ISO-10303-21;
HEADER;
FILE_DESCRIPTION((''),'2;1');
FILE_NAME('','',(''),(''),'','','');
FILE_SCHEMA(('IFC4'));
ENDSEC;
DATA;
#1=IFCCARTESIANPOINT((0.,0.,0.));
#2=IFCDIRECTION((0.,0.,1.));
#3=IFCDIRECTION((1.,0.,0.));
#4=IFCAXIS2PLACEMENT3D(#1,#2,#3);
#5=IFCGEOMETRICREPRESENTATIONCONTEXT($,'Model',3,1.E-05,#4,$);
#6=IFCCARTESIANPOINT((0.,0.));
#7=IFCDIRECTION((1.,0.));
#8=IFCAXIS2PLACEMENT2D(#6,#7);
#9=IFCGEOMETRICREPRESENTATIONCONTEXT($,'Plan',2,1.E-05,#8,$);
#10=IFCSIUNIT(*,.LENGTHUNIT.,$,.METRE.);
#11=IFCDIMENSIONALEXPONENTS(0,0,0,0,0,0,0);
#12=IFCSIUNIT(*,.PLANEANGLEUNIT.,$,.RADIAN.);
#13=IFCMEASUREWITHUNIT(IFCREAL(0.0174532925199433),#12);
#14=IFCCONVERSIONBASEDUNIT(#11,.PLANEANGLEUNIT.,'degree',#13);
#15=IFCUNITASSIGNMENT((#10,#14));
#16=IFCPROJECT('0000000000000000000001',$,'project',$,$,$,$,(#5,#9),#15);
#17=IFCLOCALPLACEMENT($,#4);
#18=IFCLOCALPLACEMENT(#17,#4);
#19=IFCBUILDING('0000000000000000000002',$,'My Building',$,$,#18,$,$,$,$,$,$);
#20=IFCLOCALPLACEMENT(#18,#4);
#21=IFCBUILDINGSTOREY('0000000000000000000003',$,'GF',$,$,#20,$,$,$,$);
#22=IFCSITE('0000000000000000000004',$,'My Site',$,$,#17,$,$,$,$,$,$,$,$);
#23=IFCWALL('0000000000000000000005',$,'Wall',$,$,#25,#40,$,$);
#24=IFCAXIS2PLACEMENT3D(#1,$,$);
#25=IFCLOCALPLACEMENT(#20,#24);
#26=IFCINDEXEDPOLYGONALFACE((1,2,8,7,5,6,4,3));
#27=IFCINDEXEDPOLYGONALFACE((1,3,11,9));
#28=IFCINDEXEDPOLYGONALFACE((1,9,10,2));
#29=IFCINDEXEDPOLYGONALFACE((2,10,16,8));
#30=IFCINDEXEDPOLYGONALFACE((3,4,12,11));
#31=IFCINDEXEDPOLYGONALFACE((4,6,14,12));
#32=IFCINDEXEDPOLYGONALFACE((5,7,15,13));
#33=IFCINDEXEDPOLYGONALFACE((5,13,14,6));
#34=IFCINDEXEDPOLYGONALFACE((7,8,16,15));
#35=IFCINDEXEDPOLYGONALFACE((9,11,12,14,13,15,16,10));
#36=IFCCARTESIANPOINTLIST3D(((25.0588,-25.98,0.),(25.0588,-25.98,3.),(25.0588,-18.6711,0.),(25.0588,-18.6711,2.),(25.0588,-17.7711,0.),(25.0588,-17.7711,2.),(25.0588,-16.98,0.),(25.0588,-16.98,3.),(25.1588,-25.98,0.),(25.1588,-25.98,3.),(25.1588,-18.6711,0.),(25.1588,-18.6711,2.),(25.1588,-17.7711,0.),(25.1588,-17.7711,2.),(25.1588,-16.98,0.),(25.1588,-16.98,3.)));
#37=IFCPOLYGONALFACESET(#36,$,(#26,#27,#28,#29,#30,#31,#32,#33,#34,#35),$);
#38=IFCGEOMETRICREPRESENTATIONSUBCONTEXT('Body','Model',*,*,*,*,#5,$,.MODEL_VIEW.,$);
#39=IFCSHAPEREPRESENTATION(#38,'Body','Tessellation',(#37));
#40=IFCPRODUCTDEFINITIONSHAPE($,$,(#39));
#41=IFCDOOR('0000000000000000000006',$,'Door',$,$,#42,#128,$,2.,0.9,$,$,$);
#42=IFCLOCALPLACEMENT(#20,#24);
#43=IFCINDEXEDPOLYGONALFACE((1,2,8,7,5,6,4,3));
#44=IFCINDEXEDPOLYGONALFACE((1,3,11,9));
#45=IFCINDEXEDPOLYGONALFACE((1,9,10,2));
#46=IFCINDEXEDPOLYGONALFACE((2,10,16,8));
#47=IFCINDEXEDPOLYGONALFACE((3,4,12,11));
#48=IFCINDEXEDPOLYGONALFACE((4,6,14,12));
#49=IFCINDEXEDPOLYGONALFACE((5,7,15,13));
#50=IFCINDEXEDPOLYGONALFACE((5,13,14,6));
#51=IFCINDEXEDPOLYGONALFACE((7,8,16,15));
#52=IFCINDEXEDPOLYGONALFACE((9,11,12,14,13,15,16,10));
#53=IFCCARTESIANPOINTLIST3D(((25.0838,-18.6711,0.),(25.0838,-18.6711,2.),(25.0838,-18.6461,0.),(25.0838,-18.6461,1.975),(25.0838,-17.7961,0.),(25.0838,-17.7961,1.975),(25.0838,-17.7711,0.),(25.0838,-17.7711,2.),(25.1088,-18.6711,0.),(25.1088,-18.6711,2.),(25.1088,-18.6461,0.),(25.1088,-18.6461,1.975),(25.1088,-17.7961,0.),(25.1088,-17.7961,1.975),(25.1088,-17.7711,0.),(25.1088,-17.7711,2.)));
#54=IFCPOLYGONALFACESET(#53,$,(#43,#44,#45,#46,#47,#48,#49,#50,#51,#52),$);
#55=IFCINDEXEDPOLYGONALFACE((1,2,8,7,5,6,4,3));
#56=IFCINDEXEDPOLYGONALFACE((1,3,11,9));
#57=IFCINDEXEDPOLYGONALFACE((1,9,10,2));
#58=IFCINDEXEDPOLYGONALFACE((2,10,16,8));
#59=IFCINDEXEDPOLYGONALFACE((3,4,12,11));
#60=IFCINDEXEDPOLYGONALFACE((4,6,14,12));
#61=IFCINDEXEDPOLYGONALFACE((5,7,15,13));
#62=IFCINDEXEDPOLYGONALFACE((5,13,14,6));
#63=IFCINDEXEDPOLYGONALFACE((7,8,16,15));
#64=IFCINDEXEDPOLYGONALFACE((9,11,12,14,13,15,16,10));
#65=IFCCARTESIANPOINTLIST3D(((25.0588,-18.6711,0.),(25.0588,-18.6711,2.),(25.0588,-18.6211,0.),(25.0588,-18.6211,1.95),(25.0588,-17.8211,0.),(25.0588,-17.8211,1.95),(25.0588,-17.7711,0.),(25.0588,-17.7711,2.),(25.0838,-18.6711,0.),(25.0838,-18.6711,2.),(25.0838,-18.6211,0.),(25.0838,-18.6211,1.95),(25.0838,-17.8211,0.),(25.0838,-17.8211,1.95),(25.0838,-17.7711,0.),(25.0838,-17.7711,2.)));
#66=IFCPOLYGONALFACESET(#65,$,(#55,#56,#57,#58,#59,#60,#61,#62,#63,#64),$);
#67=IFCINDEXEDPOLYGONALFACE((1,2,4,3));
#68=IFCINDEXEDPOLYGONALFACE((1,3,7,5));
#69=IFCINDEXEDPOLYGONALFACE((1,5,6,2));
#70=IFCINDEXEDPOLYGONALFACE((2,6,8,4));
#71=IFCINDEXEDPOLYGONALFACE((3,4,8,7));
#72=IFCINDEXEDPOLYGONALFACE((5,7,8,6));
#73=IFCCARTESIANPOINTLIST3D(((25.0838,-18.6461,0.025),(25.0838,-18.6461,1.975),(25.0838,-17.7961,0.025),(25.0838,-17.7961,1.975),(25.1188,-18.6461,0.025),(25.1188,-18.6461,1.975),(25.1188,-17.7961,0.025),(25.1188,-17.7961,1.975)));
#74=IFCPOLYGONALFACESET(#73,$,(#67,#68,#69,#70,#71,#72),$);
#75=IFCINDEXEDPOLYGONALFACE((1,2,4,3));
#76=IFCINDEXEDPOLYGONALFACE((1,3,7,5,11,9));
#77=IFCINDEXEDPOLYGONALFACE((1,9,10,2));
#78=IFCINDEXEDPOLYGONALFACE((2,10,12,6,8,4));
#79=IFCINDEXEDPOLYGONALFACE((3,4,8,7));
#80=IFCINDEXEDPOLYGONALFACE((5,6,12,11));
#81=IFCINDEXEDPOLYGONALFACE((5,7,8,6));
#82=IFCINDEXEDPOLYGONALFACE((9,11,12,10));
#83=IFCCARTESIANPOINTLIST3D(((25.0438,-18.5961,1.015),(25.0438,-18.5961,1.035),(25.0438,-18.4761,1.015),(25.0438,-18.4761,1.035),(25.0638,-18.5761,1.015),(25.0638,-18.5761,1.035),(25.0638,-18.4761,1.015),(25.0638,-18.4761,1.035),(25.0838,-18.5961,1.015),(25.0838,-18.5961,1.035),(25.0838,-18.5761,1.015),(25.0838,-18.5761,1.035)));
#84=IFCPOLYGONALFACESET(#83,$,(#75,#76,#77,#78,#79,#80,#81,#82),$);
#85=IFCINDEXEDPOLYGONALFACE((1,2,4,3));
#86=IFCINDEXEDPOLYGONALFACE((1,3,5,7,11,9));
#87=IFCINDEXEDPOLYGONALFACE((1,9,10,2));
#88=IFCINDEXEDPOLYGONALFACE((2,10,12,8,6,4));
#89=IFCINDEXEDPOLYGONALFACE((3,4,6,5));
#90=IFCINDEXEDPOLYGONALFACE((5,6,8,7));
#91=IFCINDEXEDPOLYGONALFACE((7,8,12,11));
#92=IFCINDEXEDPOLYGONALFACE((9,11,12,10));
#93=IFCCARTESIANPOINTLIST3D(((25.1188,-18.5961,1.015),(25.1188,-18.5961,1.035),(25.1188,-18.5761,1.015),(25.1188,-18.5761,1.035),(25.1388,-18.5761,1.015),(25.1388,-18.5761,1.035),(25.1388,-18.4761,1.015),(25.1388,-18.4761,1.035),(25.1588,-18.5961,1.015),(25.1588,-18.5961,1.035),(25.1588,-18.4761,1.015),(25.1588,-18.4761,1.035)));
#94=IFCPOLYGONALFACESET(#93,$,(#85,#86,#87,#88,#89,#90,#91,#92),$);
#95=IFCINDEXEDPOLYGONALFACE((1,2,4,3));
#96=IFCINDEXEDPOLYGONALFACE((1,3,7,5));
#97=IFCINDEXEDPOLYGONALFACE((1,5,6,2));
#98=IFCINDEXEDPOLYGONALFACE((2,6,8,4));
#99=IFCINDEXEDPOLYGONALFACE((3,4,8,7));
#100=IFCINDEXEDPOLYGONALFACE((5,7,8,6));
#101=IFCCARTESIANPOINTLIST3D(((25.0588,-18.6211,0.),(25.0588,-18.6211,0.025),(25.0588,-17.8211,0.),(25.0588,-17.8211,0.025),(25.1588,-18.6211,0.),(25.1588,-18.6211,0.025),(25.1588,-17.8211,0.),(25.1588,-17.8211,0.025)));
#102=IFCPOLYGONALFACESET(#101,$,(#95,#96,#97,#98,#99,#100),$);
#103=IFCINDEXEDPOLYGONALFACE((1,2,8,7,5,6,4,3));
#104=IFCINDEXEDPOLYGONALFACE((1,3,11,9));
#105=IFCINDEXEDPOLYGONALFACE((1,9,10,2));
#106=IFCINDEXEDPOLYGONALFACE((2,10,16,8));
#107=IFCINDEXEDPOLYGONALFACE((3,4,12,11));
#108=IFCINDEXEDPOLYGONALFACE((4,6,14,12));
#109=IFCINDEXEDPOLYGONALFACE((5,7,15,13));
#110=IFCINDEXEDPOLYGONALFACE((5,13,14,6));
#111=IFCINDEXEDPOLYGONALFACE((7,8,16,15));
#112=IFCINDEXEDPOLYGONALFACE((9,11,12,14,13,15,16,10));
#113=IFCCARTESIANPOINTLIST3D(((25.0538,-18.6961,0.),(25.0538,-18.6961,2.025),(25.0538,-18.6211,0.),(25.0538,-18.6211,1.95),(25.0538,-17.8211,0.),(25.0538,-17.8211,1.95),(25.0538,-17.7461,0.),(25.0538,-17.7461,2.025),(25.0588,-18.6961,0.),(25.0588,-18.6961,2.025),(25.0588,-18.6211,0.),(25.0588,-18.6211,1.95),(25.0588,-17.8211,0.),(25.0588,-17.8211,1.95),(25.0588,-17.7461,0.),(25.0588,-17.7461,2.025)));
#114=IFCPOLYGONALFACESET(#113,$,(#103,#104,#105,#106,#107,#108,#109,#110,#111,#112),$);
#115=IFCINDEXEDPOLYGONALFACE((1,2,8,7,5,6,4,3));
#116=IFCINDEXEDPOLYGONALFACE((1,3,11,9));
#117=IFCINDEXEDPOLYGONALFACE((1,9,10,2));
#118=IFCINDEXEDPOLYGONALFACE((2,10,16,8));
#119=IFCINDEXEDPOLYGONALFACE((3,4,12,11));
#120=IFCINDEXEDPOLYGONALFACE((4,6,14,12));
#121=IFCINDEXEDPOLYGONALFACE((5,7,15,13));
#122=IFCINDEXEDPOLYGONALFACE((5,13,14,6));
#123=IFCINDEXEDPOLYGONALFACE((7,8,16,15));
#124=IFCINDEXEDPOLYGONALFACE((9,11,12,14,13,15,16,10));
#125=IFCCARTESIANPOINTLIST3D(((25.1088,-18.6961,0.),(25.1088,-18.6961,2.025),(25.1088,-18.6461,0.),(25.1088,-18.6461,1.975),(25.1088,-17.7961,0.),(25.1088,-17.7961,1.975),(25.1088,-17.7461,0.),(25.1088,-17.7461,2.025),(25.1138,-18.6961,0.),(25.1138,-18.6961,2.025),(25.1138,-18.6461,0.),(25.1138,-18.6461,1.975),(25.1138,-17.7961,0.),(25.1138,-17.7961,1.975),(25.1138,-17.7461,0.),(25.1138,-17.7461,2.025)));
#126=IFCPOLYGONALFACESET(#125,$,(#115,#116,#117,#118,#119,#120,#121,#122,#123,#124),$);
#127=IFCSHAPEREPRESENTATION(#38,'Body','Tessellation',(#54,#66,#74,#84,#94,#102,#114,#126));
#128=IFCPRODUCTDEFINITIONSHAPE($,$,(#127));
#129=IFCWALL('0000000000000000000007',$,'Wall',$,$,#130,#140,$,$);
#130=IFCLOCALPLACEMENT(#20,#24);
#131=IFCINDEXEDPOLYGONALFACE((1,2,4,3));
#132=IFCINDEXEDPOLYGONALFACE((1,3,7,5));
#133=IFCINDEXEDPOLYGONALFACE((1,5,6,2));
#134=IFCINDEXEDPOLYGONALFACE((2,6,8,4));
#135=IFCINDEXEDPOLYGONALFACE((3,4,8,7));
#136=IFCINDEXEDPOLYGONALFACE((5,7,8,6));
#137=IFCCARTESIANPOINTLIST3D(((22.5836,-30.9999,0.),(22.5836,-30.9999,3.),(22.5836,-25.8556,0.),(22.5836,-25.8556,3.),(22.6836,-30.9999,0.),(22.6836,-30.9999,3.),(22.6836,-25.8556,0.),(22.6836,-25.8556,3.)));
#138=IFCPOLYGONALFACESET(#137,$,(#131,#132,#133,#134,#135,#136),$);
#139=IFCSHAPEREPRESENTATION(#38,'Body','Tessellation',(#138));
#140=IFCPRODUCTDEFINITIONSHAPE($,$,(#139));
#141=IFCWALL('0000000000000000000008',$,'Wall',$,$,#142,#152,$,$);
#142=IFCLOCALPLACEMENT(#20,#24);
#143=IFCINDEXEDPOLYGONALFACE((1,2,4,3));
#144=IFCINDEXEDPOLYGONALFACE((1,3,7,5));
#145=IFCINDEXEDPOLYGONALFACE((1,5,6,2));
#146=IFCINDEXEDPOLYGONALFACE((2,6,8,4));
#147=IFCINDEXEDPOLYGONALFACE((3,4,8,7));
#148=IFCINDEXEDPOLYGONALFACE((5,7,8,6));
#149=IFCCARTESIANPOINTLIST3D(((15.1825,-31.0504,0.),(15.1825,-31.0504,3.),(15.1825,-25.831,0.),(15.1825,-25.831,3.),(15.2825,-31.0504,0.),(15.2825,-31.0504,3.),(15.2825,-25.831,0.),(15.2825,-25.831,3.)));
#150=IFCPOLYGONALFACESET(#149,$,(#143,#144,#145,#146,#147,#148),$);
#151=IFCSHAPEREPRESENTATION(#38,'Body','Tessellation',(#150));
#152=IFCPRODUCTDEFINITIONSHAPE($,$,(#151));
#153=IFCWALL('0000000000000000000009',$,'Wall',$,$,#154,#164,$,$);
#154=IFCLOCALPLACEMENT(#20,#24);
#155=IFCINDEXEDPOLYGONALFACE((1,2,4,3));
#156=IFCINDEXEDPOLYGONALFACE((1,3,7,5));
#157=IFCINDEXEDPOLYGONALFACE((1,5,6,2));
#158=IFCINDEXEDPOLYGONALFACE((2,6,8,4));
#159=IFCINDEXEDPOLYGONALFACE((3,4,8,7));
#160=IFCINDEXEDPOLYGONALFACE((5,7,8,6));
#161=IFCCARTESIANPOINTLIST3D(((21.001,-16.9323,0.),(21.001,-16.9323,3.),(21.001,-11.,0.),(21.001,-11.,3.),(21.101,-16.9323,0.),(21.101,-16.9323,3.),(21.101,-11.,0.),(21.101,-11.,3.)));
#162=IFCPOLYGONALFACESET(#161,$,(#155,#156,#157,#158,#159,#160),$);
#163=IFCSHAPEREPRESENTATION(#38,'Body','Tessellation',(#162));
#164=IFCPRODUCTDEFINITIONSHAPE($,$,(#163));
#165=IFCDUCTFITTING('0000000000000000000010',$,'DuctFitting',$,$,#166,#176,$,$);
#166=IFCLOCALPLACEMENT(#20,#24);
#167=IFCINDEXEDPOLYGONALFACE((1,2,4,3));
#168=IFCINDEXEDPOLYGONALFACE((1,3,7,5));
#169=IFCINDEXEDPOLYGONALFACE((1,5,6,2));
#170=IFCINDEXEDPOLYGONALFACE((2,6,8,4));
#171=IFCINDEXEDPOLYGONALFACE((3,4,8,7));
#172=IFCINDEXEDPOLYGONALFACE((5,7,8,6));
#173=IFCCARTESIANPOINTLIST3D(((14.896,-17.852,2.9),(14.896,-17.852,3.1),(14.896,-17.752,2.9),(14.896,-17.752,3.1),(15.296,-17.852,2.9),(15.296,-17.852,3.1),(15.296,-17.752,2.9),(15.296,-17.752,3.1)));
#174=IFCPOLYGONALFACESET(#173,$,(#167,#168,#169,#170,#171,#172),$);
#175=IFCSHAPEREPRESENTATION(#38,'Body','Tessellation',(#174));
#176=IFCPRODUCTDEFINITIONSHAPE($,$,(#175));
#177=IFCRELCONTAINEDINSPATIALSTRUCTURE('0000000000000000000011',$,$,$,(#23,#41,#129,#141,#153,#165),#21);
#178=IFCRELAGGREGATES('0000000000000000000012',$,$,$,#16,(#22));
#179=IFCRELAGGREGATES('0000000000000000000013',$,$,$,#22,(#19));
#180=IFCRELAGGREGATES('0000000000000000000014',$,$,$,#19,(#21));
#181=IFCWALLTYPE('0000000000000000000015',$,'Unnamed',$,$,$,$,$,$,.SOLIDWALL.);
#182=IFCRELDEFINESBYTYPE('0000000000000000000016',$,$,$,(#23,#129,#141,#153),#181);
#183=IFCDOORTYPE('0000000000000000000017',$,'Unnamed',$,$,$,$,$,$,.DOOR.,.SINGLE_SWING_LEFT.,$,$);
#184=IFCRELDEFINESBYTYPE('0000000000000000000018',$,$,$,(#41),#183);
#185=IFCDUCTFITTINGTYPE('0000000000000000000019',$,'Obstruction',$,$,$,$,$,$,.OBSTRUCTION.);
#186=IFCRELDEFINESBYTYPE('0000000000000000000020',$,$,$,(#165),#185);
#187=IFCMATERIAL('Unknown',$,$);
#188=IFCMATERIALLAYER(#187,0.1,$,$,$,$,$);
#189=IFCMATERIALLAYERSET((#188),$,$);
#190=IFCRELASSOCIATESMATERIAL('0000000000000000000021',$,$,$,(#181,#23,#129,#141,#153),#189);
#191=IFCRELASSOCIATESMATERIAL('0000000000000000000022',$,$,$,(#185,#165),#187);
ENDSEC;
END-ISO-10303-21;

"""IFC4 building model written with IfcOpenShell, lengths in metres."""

from ifc_helpers import new_model, entity, si_unit, converted_unit, frame, origin_with_axes, origin_2d_with_axis, place, context, subcontext, project, spatial, line, indexed_curve, rectangle, outline, extrude, shape, source, transform, mapped, material, layer, layer_set, layer_usage, material_profile, profile_set, profile_usage, type_object, type_shapes, element, fill, save


model = new_model("IFC4")

# Units and contexts
model_context = context("Model", 3, precision=1e-05, world=origin_with_axes())
plan_context = context("Plan", 2, precision=1e-05, world=origin_2d_with_axis())
body_context_1 = subcontext(model_context, "Body", "Model", "MODEL_VIEW")
body_context_2 = subcontext(plan_context, "Body", "Plan", "PLAN_VIEW")
ifc_project = project(units=[si_unit("LENGTHUNIT", "METRE"), converted_unit("PLANEANGLEUNIT", "degree", entity("IfcReal", 0.0174532925199433), si_unit("PLANEANGLEUNIT", "RADIAN"), dimensions=[0, 0, 0, 0, 0, 0, 0])], contexts=[model_context, plan_context])

# Site, building, storey
site_placement = place(None, origin_with_axes())
site = spatial("IfcSite", under=ifc_project, at=site_placement, Name="My Site")
building_placement = place(site_placement, origin_with_axes())
building = spatial("IfcBuilding", under=site, at=building_placement, Name="My Building")
storey_placement = place(building_placement, origin_with_axes())
storey = spatial("IfcBuildingStorey", under=building, at=storey_placement, Name="GF")

# Shared definitions
ifc_material = material(Name="Unknown")
ifc_layer = layer(ifc_material, 0.1)
ifc_layer_set = layer_set([ifc_layer])
wall_type = type_object("IfcWallType", Name="Unnamed", PredefinedType="SOLIDWALL", material=ifc_layer_set)

# Shared definitions
shared_shape_1 = source(origin_with_axes(), body_context_1, "Body", "SweptSolid", [
    extrude(outline(indexed_curve([(0.0, 0.0), (0.9, 0.0), (0.9, 2.0), (0.0, 2.0)], segments=[line(1, 2, 3, 4, 1)])), frame((0.0, -0.6, 0.0), z_axis=(0.0, -1.0, 0.0), x_axis=(1.0, 0.0, 0.0)), (0.0, 0.0, -1.0), 1.2),
])
door_type = type_object("IfcDoorType", Name="Unnamed", OperationType="SINGLE_SWING_LEFT", PredefinedType="DOOR")
shared_shape_2 = source(origin_with_axes(), body_context_1, "Body", "SweptSolid", [
    extrude(outline(indexed_curve([(0.0, 0.0), (0.0, 2.0), (0.9, 2.0), (0.9, 0.0), (0.875, 0.0), (0.875, 1.975), (0.025, 1.975), (0.025, 0.0)], segments=[line(1, 2, 3, 4, 5, 6, 7, 8, 1)])), frame((0.0, 0.025, 0.0), z_axis=(0.0, -1.0, 0.0), x_axis=(1.0, 0.0, 0.0)), (0.0, 0.0, -1.0), 0.025),
    extrude(outline(indexed_curve([(0.0, 0.0), (0.0, 2.0), (0.9, 2.0), (0.9, 0.0), (0.85, 0.0), (0.85, 1.95), (0.05, 1.95), (0.05, 0.0)], segments=[line(1, 2, 3, 4, 5, 6, 7, 8, 1)])), frame((0.0, 0.0, 0.0), z_axis=(0.0, -1.0, 0.0), x_axis=(1.0, 0.0, 0.0)), (0.0, 0.0, -1.0), 0.025),
    extrude(outline(indexed_curve([(0.0, 0.0), (0.85, 0.0), (0.85, 0.035), (0.0, 0.035)], segments=[line(1, 2, 3, 4, 1)])), frame((0.025, 0.025, 0.025), z_axis=(0.0, 0.0, 1.0), x_axis=(1.0, 0.0, 0.0)), (0.0, 0.0, 1.0), 1.95),
    extrude(outline(indexed_curve([(0.0, 0.0), (0.0, -0.04), (-0.12, -0.04), (-0.12, -0.02), (-0.02, -0.02), (-0.02, 0.0)], segments=[line(1, 2, 3, 4, 5, 6, 1)])), frame((0.825, 0.025, 1.015), z_axis=(0.0, 0.0, 1.0), x_axis=(1.0, 0.0, 0.0)), (0.0, 0.0, 1.0), 0.02),
    extrude(outline(indexed_curve([(0.0, 0.0), (0.0, 0.04), (-0.12, 0.04), (-0.12, 0.02), (-0.02, 0.02), (-0.02, 0.0)], segments=[line(1, 2, 3, 4, 5, 6, 1)])), frame((0.825, 0.06, 1.015), z_axis=(0.0, 0.0, 1.0), x_axis=(1.0, 0.0, 0.0)), (0.0, 0.0, 1.0), 0.02),
    extrude(outline(indexed_curve([(0.0, 0.0), (0.8, 0.0), (0.8, 0.1), (0.0, 0.1)], segments=[line(1, 2, 3, 4, 1)])), frame((0.05, 0.0, 0.0), z_axis=(0.0, 0.0, 1.0), x_axis=(1.0, 0.0, 0.0)), (0.0, 0.0, 1.0), 0.025),
    extrude(outline(indexed_curve([(0.0, 0.0), (0.0, 2.025), (0.95, 2.025), (0.95, 0.0), (0.875, 0.0), (0.875, 1.95), (0.075, 1.95), (0.075, 0.0)], segments=[line(1, 2, 3, 4, 5, 6, 7, 8, 1)])), frame((-0.025, -0.005, 0.0), z_axis=(0.0, -1.0, 0.0), x_axis=(1.0, 0.0, 0.0)), (0.0, 0.0, -1.0), 0.005),
    extrude(outline(indexed_curve([(0.0, 0.0), (0.0, 2.025), (0.95, 2.025), (0.95, 0.0), (0.9, 0.0), (0.9, 1.975), (0.05, 1.975), (0.05, 0.0)], segments=[line(1, 2, 3, 4, 5, 6, 7, 8, 1)])), frame((-0.025, 0.05, 0.0), z_axis=(0.0, -1.0, 0.0), x_axis=(1.0, 0.0, 0.0)), (0.0, 0.0, -1.0), 0.005),
])
shared_shape_3 = source(origin_with_axes(), body_context_2, "Body", "Curve2D", [
    entity("IfcIndexedPolyCurve", entity("IfcCartesianPointList2D", [[0.0, 0.0], [0.0, 0.05], [0.025, 0.05], [0.025, 0.025], [0.05, 0.025], [0.05, 0.0]]), [entity("IfcLineIndex", [1, 2, 3, 4, 5, 6, 1])]),
    entity("IfcIndexedPolyCurve", entity("IfcCartesianPointList2D", [[0.9, 0.0], [0.9, 0.05], [0.875, 0.05], [0.875, 0.025], [0.85, 0.025], [0.85, 0.0]]), [entity("IfcLineIndex", [1, 2, 3, 4, 5, 6, 1])]),
    entity("IfcTrimmedCurve", entity("IfcEllipse", entity("IfcAxis2Placement2D", entity("IfcCartesianPoint", [0.06, 0.05]), entity("IfcDirection", [1.0, 0.0])), 0.815, 0.85), [entity("IfcCartesianPoint", [0.875, 0.05])], [entity("IfcCartesianPoint", [0.06, 0.9])], True, "CARTESIAN"),
    entity("IfcIndexedPolyCurve", entity("IfcCartesianPointList2D", [[0.025, 0.05], [0.06, 0.05], [0.06, 0.9], [0.025, 0.9]]), [entity("IfcLineIndex", [1, 2, 3, 4, 1])]),
])
type_shapes(door_type, [shared_shape_2, shared_shape_3])

# Wall, opening, door
ifc_layer_usage_1 = layer_usage(ifc_layer_set, "AXIS2", "POSITIVE", 0.0)
wall_1_placement = place(storey_placement, frame((25.0588, -16.98, 0.0), z_axis=(0.0, 0.0, 1.0), x_axis=(0.0, -1.0, 0.0)))
wall_1 = element("IfcWall", 1, at=wall_1_placement, inside=storey, type_object=wall_type, material=ifc_layer_usage_1, Name="Wall", context=body_context_1, shape_type="SweptSolid", body=[
    extrude(outline(indexed_curve([(0.0, 0.0), (0.0, 0.1), (9.0, 0.1), (9.0, 0.0)], segments=[line(1, 2, 3, 4, 1)])), origin_with_axes(), (0.0, 0.0, 1.0), 3.0),
])
opening_1_placement = place(wall_1_placement, frame((0.7911, 0.0, 0.0), z_axis=(0.0, 0.0, 1.0), x_axis=(1.0, 0.0, 0.0)))
opening_1 = element("IfcOpeningElement", 2, at=opening_1_placement, cuts=wall_1, PredefinedType="OPENING", context=body_context_1, shape_type="MappedRepresentation", body=[
    mapped(shared_shape_1, transform((0.0, 0.0, 0.0), x_axis=(1.0, 0.0, 0.0), y_axis=(0.0, 1.0, 0.0), z_axis=(0.0, 0.0, 1.0), scale=1.0)),
])
door_1_placement = place(opening_1_placement, frame((0.0, 0.0, 0.0), z_axis=(0.0, 0.0, 1.0), x_axis=(1.0, 0.0, 0.0)))
door_1 = element("IfcDoor", 3, at=door_1_placement, inside=storey, type_object=door_type, Name="Door", OverallHeight=2.0, OverallWidth=0.9, shapes=[
    shape(body_context_1, "Body", "MappedRepresentation", [mapped(shared_shape_2, transform((0.0, 0.0, 0.0), x_axis=(1.0, 0.0, 0.0), y_axis=(0.0, 1.0, 0.0), z_axis=(0.0, 0.0, 1.0), scale=1.0))]),
    shape(body_context_2, "Body", "MappedRepresentation", [mapped(shared_shape_3, transform((0.0, 0.0, 0.0), x_axis=(1.0, 0.0, 0.0), y_axis=(0.0, 1.0, 0.0), z_axis=(0.0, 0.0, 1.0), scale=1.0))]),
])
fill(opening_1, door_1)

# Walls
ifc_layer_usage_2 = layer_usage(ifc_layer_set, "AXIS2", "POSITIVE", 0.0)
wall_2_placement = place(storey_placement, frame((22.5836, -25.8556, 0.0), z_axis=(0.0, 0.0, 1.0), x_axis=(0.0, -1.0, 0.0)))
element("IfcWall", 4, at=wall_2_placement, inside=storey, type_object=wall_type, material=ifc_layer_usage_2, Name="Wall", context=body_context_1, shape_type="SweptSolid", body=[
    extrude(outline(indexed_curve([(0.0, 0.0), (0.0, 0.1), (5.1443, 0.1), (5.1443, 0.0)], segments=[line(1, 2, 3, 4, 1)])), origin_with_axes(), (0.0, 0.0, 1.0), 3.0),
])
ifc_layer_usage_3 = layer_usage(ifc_layer_set, "AXIS2", "POSITIVE", 0.0)
wall_3_placement = place(storey_placement, frame((15.1825, -25.831, 0.0), z_axis=(0.0, 0.0, 1.0), x_axis=(0.0, -1.0, 0.0)))
element("IfcWall", 5, at=wall_3_placement, inside=storey, type_object=wall_type, material=ifc_layer_usage_3, Name="Wall", context=body_context_1, shape_type="SweptSolid", body=[
    extrude(outline(indexed_curve([(0.0, 0.0), (0.0, 0.1), (5.2194, 0.1), (5.2194, 0.0)], segments=[line(1, 2, 3, 4, 1)])), origin_with_axes(), (0.0, 0.0, 1.0), 3.0),
])
ifc_layer_usage_4 = layer_usage(ifc_layer_set, "AXIS2", "POSITIVE", 0.0)
wall_4_placement = place(storey_placement, frame((21.101, -16.9323, 0.0), z_axis=(0.0, 0.0, 1.0), x_axis=(0.0, 1.0, 0.0)))
element("IfcWall", 6, at=wall_4_placement, inside=storey, type_object=wall_type, material=ifc_layer_usage_4, Name="Wall", context=body_context_1, shape_type="SweptSolid", body=[
    extrude(outline(indexed_curve([(0.0, 0.0), (0.0, 0.1), (5.9323, 0.1), (5.9323, 0.0)], segments=[line(1, 2, 3, 4, 1)])), origin_with_axes(), (0.0, 0.0, 1.0), 3.0),
])

# Duct fitting
ifc_material_profile = material_profile(ifc_material, rectangle(XDim=0.4, YDim=0.2))
ifc_profile_set = profile_set([ifc_material_profile])
ifc_profile_usage_1 = profile_usage(ifc_profile_set, cardinal=5)
duct_fitting_type = type_object("IfcDuctFittingType", Name="Obstruction", PredefinedType="OBSTRUCTION", material=ifc_profile_set)
duct_fitting_1_placement = place(storey_placement, frame((15.096, -17.852, 3.0), z_axis=(0.0, 1.0, 0.0), x_axis=(-1.0, 0.0, 0.0)))
element("IfcDuctFitting", 7, at=duct_fitting_1_placement, inside=storey, type_object=duct_fitting_type, material=ifc_profile_usage_1, Name="DuctFitting", context=body_context_1, shape_type="SweptSolid", body=[
    extrude(rectangle(XDim=0.4, YDim=0.2), origin_with_axes(), (0.0, 0.0, 1.0), 0.1),
])

save(model, "model.ifc")
